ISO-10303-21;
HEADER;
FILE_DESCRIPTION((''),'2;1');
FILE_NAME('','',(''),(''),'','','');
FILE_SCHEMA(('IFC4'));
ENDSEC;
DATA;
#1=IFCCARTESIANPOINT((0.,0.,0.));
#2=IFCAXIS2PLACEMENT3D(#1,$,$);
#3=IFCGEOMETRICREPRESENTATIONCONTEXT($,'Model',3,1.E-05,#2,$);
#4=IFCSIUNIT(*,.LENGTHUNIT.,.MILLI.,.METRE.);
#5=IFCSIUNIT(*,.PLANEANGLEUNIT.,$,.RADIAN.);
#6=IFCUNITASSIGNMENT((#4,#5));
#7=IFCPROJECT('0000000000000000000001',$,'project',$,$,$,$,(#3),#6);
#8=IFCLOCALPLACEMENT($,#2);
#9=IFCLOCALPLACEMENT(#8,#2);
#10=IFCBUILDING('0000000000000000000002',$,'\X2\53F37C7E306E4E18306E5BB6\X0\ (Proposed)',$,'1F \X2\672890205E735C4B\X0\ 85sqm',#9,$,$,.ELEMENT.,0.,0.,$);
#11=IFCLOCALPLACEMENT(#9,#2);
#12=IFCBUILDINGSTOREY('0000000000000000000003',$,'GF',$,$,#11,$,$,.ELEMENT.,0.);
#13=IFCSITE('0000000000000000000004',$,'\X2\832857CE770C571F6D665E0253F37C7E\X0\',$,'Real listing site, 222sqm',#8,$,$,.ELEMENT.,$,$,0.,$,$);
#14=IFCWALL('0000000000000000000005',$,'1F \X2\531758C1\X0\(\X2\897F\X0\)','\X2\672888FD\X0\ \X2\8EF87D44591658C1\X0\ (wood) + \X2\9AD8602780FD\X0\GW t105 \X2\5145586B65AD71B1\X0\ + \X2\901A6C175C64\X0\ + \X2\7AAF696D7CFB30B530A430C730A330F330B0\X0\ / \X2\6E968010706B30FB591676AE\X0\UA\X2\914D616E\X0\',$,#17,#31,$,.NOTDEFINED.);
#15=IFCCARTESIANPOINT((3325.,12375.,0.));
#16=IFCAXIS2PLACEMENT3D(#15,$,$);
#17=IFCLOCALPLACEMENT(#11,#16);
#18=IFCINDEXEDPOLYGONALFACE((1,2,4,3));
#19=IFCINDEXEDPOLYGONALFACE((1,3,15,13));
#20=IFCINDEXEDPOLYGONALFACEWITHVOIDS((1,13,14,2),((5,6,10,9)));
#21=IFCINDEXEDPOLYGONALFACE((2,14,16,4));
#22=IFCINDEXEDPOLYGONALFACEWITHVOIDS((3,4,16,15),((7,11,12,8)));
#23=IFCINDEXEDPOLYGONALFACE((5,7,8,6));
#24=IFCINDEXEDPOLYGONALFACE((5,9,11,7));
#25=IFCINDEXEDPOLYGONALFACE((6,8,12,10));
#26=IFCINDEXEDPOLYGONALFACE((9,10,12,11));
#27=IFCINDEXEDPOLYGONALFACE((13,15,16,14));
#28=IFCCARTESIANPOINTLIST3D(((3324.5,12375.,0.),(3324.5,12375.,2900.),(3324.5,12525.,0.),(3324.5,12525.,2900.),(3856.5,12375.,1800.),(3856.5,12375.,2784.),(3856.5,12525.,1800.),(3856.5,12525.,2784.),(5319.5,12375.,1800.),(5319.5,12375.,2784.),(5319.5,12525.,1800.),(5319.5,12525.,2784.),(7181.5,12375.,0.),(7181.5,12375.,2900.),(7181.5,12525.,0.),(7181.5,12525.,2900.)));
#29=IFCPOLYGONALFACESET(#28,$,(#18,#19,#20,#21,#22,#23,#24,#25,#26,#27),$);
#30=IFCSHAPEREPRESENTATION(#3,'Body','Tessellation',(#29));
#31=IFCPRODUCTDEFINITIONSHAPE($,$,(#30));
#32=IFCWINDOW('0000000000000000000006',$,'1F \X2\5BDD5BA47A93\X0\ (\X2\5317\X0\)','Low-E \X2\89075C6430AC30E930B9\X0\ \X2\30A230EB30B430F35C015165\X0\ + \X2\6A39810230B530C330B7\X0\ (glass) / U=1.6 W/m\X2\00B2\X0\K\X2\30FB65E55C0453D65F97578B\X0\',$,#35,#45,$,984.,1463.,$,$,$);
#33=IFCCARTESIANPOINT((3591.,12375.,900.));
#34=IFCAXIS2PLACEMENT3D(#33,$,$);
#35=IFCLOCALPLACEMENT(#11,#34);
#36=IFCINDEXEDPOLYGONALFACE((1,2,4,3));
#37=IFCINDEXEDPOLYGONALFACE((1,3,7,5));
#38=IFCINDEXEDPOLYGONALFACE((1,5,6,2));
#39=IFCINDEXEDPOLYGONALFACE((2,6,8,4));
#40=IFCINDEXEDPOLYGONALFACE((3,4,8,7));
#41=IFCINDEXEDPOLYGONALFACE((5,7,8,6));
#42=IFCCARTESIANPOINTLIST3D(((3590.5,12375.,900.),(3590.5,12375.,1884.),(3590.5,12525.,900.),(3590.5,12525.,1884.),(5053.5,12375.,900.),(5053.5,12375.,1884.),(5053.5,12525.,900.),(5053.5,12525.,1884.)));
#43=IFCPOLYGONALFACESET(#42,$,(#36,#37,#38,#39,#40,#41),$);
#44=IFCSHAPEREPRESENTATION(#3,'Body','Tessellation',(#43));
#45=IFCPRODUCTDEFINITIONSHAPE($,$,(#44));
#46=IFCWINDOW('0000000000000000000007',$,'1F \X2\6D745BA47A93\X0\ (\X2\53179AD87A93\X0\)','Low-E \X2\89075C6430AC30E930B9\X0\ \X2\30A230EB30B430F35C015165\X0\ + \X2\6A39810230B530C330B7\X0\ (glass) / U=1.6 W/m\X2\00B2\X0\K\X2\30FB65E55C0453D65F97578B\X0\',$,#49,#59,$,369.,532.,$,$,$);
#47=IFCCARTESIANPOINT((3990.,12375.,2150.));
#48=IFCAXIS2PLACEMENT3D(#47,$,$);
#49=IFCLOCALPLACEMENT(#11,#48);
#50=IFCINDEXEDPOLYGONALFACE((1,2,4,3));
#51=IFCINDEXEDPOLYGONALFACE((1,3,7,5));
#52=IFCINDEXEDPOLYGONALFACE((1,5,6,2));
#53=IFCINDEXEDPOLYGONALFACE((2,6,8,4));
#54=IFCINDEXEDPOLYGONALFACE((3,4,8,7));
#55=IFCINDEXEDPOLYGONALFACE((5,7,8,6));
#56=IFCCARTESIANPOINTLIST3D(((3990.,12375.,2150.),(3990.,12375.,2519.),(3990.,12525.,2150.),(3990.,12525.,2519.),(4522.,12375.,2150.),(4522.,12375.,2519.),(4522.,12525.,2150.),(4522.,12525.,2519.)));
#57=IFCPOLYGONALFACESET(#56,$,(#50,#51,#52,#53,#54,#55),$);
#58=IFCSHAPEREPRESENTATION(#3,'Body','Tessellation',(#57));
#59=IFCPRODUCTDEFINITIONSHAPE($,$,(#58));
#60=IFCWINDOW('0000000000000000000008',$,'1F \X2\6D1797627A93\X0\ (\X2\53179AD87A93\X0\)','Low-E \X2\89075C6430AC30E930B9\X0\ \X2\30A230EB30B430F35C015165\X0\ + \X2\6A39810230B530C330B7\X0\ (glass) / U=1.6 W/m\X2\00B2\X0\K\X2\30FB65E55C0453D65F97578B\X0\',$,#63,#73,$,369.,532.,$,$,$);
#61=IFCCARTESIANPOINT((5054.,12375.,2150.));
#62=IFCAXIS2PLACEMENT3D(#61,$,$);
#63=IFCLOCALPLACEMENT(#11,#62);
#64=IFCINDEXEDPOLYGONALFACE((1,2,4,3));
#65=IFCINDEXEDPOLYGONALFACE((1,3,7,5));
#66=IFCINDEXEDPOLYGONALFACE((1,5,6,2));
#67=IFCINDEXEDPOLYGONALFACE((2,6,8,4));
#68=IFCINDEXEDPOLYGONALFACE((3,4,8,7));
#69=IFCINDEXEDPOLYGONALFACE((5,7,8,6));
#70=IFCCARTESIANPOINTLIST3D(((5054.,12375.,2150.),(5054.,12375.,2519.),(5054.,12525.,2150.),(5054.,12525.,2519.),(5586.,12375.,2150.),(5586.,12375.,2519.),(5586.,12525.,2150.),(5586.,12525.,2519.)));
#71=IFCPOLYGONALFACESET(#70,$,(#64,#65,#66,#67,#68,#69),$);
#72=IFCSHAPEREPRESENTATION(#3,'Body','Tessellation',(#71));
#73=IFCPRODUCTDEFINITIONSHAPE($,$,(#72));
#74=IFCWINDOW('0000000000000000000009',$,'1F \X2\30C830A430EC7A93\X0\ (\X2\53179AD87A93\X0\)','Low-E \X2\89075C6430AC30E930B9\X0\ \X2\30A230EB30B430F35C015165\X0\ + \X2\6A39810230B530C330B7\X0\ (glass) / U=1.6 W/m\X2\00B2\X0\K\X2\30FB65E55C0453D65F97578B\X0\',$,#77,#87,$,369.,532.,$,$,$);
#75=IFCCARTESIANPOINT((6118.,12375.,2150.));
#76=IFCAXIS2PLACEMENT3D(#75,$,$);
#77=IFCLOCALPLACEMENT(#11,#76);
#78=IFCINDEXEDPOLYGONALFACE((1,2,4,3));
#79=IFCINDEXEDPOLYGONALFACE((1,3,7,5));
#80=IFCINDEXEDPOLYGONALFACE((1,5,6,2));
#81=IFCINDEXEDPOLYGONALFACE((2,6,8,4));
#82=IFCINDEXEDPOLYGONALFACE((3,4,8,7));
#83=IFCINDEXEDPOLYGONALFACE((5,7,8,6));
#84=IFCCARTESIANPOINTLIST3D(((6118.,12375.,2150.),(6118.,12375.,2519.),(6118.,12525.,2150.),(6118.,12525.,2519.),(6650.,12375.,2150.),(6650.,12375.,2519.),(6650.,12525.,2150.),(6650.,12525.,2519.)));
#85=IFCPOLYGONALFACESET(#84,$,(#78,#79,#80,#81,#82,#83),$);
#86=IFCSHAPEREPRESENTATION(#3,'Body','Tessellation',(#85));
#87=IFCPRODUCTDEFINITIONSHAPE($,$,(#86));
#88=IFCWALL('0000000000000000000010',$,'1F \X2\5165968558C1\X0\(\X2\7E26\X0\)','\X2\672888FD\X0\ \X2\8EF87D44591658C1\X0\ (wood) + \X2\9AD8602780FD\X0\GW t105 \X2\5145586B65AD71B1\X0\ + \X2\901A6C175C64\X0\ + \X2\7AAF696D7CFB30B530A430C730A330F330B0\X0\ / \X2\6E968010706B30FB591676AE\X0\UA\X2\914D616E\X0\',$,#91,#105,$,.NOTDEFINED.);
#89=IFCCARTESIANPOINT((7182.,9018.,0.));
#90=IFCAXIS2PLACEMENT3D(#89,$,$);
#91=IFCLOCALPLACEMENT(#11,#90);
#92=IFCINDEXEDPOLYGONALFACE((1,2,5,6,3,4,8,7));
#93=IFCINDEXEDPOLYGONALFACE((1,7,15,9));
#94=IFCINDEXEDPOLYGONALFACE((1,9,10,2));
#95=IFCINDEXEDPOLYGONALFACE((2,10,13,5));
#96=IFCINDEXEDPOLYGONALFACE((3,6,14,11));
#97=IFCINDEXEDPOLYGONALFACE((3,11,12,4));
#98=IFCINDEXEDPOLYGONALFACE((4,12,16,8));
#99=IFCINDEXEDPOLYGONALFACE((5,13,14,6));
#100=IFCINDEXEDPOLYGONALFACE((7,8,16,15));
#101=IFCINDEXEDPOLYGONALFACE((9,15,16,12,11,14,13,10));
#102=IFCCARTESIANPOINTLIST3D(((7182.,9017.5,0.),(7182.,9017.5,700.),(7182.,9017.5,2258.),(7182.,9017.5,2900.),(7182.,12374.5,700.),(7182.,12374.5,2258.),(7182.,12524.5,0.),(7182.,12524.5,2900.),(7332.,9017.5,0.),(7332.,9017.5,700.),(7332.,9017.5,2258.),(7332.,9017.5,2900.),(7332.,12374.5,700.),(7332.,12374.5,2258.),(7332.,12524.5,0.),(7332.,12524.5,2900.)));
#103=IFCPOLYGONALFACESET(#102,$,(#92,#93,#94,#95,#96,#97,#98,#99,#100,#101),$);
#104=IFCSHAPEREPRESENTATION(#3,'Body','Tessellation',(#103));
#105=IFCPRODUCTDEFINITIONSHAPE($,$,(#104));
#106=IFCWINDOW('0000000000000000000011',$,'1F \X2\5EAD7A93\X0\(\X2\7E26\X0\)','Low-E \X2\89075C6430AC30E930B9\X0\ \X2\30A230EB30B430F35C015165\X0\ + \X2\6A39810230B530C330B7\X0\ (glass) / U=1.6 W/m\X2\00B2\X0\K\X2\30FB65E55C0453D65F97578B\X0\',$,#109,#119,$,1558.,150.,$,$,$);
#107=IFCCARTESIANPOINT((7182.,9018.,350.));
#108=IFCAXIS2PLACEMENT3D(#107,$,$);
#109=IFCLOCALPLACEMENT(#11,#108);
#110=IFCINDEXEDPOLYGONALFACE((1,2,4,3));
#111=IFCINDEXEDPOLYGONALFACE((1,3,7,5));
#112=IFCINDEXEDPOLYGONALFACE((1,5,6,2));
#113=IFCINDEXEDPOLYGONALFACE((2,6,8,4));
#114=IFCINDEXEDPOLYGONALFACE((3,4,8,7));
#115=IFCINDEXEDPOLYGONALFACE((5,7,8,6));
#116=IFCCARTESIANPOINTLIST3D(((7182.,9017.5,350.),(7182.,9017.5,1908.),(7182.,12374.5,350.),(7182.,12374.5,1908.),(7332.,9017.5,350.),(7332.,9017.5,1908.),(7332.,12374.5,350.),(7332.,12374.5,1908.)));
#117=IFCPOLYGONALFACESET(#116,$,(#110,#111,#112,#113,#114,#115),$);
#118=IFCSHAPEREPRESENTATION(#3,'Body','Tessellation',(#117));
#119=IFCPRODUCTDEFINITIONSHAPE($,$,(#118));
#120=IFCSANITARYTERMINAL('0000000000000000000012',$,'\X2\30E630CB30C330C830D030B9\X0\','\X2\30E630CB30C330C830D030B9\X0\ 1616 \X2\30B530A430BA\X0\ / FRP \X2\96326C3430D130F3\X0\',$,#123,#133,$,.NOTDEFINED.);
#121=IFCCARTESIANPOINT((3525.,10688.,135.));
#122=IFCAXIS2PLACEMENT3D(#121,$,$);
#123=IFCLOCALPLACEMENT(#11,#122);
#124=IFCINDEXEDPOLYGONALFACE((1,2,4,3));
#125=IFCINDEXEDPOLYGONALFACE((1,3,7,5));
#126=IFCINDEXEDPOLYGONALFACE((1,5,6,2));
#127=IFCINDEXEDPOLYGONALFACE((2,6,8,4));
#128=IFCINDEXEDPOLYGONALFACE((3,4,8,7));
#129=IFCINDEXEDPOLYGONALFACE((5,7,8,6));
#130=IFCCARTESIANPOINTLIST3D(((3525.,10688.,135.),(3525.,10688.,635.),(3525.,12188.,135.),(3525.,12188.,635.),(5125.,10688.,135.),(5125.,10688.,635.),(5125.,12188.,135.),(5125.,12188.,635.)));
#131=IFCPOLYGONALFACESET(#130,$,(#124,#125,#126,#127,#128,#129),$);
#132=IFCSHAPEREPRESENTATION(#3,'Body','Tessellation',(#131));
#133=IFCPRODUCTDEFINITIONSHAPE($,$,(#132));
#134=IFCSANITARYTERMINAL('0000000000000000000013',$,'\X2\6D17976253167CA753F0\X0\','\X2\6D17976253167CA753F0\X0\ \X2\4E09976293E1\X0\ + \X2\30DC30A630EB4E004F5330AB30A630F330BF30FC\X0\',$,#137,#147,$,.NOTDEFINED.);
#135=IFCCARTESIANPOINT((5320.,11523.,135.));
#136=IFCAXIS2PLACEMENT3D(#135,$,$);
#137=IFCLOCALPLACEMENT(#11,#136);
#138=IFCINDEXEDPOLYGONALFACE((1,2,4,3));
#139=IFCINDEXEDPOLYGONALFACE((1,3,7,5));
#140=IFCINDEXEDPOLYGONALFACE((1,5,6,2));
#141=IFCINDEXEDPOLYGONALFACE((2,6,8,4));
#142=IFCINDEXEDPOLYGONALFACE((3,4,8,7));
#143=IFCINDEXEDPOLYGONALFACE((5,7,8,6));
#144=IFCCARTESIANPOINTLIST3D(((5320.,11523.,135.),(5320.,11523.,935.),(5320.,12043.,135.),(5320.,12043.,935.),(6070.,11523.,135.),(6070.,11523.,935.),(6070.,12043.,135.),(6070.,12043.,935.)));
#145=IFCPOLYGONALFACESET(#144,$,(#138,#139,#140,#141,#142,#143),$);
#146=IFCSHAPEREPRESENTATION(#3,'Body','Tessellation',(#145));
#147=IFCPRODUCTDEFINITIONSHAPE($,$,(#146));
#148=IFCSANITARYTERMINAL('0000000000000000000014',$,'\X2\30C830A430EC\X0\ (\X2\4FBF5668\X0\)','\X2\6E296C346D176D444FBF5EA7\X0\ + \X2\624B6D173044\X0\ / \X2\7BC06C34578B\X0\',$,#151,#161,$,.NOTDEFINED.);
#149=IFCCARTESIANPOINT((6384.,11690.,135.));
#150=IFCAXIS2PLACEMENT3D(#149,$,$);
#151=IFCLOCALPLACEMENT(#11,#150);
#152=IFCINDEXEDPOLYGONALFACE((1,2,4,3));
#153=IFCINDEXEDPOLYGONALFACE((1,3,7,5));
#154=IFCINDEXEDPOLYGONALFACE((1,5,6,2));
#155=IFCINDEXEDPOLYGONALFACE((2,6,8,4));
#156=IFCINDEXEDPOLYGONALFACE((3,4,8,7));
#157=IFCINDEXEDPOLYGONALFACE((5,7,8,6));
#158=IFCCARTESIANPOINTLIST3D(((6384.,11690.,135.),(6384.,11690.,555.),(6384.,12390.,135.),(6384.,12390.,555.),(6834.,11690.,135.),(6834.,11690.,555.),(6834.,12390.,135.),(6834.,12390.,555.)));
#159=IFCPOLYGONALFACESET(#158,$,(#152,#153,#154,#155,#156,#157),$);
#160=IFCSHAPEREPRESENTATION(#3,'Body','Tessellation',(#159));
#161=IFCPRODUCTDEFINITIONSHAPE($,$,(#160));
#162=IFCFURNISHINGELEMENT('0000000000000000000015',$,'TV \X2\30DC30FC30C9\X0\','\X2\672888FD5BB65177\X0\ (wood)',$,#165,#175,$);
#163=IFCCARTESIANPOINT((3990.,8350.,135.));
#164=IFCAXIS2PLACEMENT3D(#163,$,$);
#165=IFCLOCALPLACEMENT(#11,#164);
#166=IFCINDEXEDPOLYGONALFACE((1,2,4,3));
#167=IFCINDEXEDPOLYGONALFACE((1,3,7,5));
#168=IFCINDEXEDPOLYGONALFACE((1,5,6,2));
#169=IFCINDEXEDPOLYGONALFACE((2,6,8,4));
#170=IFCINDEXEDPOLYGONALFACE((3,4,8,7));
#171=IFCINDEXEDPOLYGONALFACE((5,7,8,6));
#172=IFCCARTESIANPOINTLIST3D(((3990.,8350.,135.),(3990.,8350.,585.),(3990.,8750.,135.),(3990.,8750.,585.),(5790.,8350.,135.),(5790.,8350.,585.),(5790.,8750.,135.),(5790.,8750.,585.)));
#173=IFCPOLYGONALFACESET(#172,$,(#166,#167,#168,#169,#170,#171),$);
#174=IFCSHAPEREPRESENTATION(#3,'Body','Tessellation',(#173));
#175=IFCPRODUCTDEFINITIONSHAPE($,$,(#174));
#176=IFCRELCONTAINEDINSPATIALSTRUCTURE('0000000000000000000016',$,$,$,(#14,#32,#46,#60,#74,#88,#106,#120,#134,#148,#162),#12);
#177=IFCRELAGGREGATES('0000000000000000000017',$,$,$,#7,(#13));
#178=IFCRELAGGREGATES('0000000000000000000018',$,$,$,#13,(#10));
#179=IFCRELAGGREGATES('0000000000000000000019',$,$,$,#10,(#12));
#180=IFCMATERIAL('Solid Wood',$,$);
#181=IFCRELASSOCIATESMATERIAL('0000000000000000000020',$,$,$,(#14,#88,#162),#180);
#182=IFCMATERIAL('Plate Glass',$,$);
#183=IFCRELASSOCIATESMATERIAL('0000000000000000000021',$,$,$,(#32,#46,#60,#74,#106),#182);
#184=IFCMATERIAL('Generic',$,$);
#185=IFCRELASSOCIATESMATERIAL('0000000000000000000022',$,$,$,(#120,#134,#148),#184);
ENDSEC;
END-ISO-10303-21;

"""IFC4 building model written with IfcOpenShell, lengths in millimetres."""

from ifc_helpers import new_model, si_unit, frame, frame_2d, origin, place, context, project, spatial, rectangle, extrude, material, element, fill, save


model = new_model("IFC4")

# Units and contexts
model_context = context("Model", 3, precision=1e-05, world=origin())
ifc_project = project(units=[si_unit("LENGTHUNIT", "METRE", prefix="MILLI"), si_unit("PLANEANGLEUNIT", "RADIAN")], contexts=[model_context])

# Site, building, storey
site_placement = place(None, origin())
site = spatial("IfcSite", under=ifc_project, at=site_placement, Name="茨城県土浦市右籾", ObjectType="Real listing site, 222sqm", CompositionType="ELEMENT", RefElevation=0.0)
building_placement = place(site_placement, origin())
building = spatial("IfcBuilding", under=site, at=building_placement, Name="右籾の丘の家 (Proposed)", ObjectType="1F 木造平屋 85sqm", CompositionType="ELEMENT", ElevationOfRefHeight=0.0, ElevationOfTerrain=0.0)
storey_placement = place(building_placement, origin())
storey = spatial("IfcBuildingStorey", under=building, at=storey_placement, Name="GF", CompositionType="ELEMENT", Elevation=0.0)

# Shared definitions
ifc_material_1 = material(Name="Solid Wood")

# Wall, openings, windows
wall_1_placement = place(storey_placement, frame((3325.0, 12375.0, 0.0)))
wall_1 = element("IfcWall", 1, at=wall_1_placement, inside=storey, material=ifc_material_1, Name="1F 北壁(西)", Description="木製 軸組外壁 (wood) + 高性能GW t105 充填断熱 + 通気層 + 窯業系サイディング / 準耐火・外皮UA配慮", PredefinedType="NOTDEFINED", context=model_context, shape_type="SweptSolid", body=[
    extrude(rectangle(XDim=3857.0, YDim=150.0, at=frame_2d((1928.0, 75.0))), frame((3325.0, 12375.0, 0.0)), (0.0, 0.0, 1.0), 2900.0),
])
opening_1_placement = place(storey_placement, frame((3591.0, 12375.0, 900.0)))
opening_1 = element("IfcOpeningElement", 2, at=opening_1_placement, cuts=wall_1, PredefinedType="NOTDEFINED", context=model_context, shape_type="SweptSolid", body=[
    extrude(rectangle(XDim=1463.0, YDim=150.0, at=frame_2d((731.0, 75.0))), frame((3591.0, 12375.0, 900.0)), (0.0, 0.0, 1.0), 984.0),
])
opening_2_placement = place(storey_placement, frame((3990.0, 12375.0, 2150.0)))
opening_2 = element("IfcOpeningElement", 3, at=opening_2_placement, cuts=wall_1, PredefinedType="NOTDEFINED", context=model_context, shape_type="SweptSolid", body=[
    extrude(rectangle(XDim=532.0, YDim=150.0, at=frame_2d((266.0, 75.0))), frame((3990.0, 12375.0, 2150.0)), (0.0, 0.0, 1.0), 369.0),
])
opening_3_placement = place(storey_placement, frame((5054.0, 12375.0, 2150.0)))
opening_3 = element("IfcOpeningElement", 4, at=opening_3_placement, cuts=wall_1, PredefinedType="NOTDEFINED", context=model_context, shape_type="SweptSolid", body=[
    extrude(rectangle(XDim=532.0, YDim=150.0, at=frame_2d((266.0, 75.0))), frame((5054.0, 12375.0, 2150.0)), (0.0, 0.0, 1.0), 369.0),
])
opening_4_placement = place(storey_placement, frame((6118.0, 12375.0, 2150.0)))
opening_4 = element("IfcOpeningElement", 5, at=opening_4_placement, cuts=wall_1, PredefinedType="NOTDEFINED", context=model_context, shape_type="SweptSolid", body=[
    extrude(rectangle(XDim=532.0, YDim=150.0, at=frame_2d((266.0, 75.0))), frame((6118.0, 12375.0, 2150.0)), (0.0, 0.0, 1.0), 369.0),
])
ifc_material_2 = material(Name="Plate Glass")
window_1_placement = place(storey_placement, frame((3591.0, 12375.0, 900.0)))
window_1 = element("IfcWindow", 6, at=window_1_placement, inside=storey, material=ifc_material_2, Name="1F 寝室窓 (北)", Description="Low-E 複層ガラス アルゴン封入 + 樹脂サッシ (glass) / U=1.6 W/m²K・日射取得型", OverallHeight=984.0, OverallWidth=1463.0, context=model_context, shape_type="SweptSolid", body=[
    extrude(rectangle(XDim=1463.0, YDim=150.0, at=frame_2d((731.0, 75.0))), frame((3591.0, 12375.0, 900.0)), (0.0, 0.0, 1.0), 984.0),
])
fill(opening_1, window_1)
window_2_placement = place(storey_placement, frame((3990.0, 12375.0, 2150.0)))
window_2 = element("IfcWindow", 7, at=window_2_placement, inside=storey, material=ifc_material_2, Name="1F 浴室窓 (北高窓)", Description="Low-E 複層ガラス アルゴン封入 + 樹脂サッシ (glass) / U=1.6 W/m²K・日射取得型", OverallHeight=369.0, OverallWidth=532.0, context=model_context, shape_type="SweptSolid", body=[
    extrude(rectangle(XDim=532.0, YDim=150.0, at=frame_2d((266.0, 75.0))), frame((3990.0, 12375.0, 2150.0)), (0.0, 0.0, 1.0), 369.0),
])
fill(opening_2, window_2)
window_3_placement = place(storey_placement, frame((5054.0, 12375.0, 2150.0)))
window_3 = element("IfcWindow", 8, at=window_3_placement, inside=storey, material=ifc_material_2, Name="1F 洗面窓 (北高窓)", Description="Low-E 複層ガラス アルゴン封入 + 樹脂サッシ (glass) / U=1.6 W/m²K・日射取得型", OverallHeight=369.0, OverallWidth=532.0, context=model_context, shape_type="SweptSolid", body=[
    extrude(rectangle(XDim=532.0, YDim=150.0, at=frame_2d((266.0, 75.0))), frame((5054.0, 12375.0, 2150.0)), (0.0, 0.0, 1.0), 369.0),
])
fill(opening_3, window_3)
window_4_placement = place(storey_placement, frame((6118.0, 12375.0, 2150.0)))
window_4 = element("IfcWindow", 9, at=window_4_placement, inside=storey, material=ifc_material_2, Name="1F トイレ窓 (北高窓)", Description="Low-E 複層ガラス アルゴン封入 + 樹脂サッシ (glass) / U=1.6 W/m²K・日射取得型", OverallHeight=369.0, OverallWidth=532.0, context=model_context, shape_type="SweptSolid", body=[
    extrude(rectangle(XDim=532.0, YDim=150.0, at=frame_2d((266.0, 75.0))), frame((6118.0, 12375.0, 2150.0)), (0.0, 0.0, 1.0), 369.0),
])
fill(opening_4, window_4)

# Wall, opening, window
wall_2_placement = place(storey_placement, frame((7182.0, 9018.0, 0.0)))
wall_2 = element("IfcWall", 10, at=wall_2_placement, inside=storey, material=ifc_material_1, Name="1F 入隅壁(縦)", Description="木製 軸組外壁 (wood) + 高性能GW t105 充填断熱 + 通気層 + 窯業系サイディング / 準耐火・外皮UA配慮", PredefinedType="NOTDEFINED", context=model_context, shape_type="SweptSolid", body=[
    extrude(rectangle(XDim=150.0, YDim=3507.0, at=frame_2d((75.0, 1753.0))), frame((7182.0, 9018.0, 0.0)), (0.0, 0.0, 1.0), 2900.0),
])
opening_5_placement = place(storey_placement, frame((7182.0, 9018.0, 350.0)))
opening_5 = element("IfcOpeningElement", 11, at=opening_5_placement, cuts=wall_2, PredefinedType="NOTDEFINED", context=model_context, shape_type="SweptSolid", body=[
    extrude(rectangle(XDim=150.0, YDim=3357.0, at=frame_2d((75.0, 1678.0))), frame((7182.0, 9018.0, 350.0)), (0.0, 0.0, 1.0), 1558.0),
])
window_5_placement = place(storey_placement, frame((7182.0, 9018.0, 350.0)))
window_5 = element("IfcWindow", 12, at=window_5_placement, inside=storey, material=ifc_material_2, Name="1F 庭窓(縦)", Description="Low-E 複層ガラス アルゴン封入 + 樹脂サッシ (glass) / U=1.6 W/m²K・日射取得型", OverallHeight=1558.0, OverallWidth=150.0, context=model_context, shape_type="SweptSolid", body=[
    extrude(rectangle(XDim=150.0, YDim=3357.0, at=frame_2d((75.0, 1678.0))), frame((7182.0, 9018.0, 350.0)), (0.0, 0.0, 1.0), 1558.0),
])
fill(opening_5, window_5)

# Shared definitions
ifc_material_3 = material(Name="Generic")

# Sanitary terminals
sanitary_terminal_1_placement = place(storey_placement, frame((3525.0, 10688.0, 135.0)))
element("IfcSanitaryTerminal", 13, at=sanitary_terminal_1_placement, inside=storey, material=ifc_material_3, Name="ユニットバス", Description="ユニットバス 1616 サイズ / FRP 防水パン", PredefinedType="NOTDEFINED", context=model_context, shape_type="SweptSolid", body=[
    extrude(rectangle(XDim=1600.0, YDim=1500.0, at=frame_2d((800.0, 750.0))), frame((3525.0, 10688.0, 135.0)), (0.0, 0.0, 1.0), 500.0),
])
sanitary_terminal_2_placement = place(storey_placement, frame((5320.0, 11523.0, 135.0)))
element("IfcSanitaryTerminal", 14, at=sanitary_terminal_2_placement, inside=storey, material=ifc_material_3, Name="洗面化粧台", Description="洗面化粧台 三面鏡 + ボウル一体カウンター", PredefinedType="NOTDEFINED", context=model_context, shape_type="SweptSolid", body=[
    extrude(rectangle(XDim=750.0, YDim=520.0, at=frame_2d((375.0, 260.0))), frame((5320.0, 11523.0, 135.0)), (0.0, 0.0, 1.0), 800.0),
])
sanitary_terminal_3_placement = place(storey_placement, frame((6384.0, 11690.0, 135.0)))
element("IfcSanitaryTerminal", 15, at=sanitary_terminal_3_placement, inside=storey, material=ifc_material_3, Name="トイレ (便器)", Description="温水洗浄便座 + 手洗い / 節水型", PredefinedType="NOTDEFINED", context=model_context, shape_type="SweptSolid", body=[
    extrude(rectangle(XDim=450.0, YDim=700.0, at=frame_2d((225.0, 350.0))), frame((6384.0, 11690.0, 135.0)), (0.0, 0.0, 1.0), 420.0),
])

# Furnishing element
furnishing_placement = place(storey_placement, frame((3990.0, 8350.0, 135.0)))
element("IfcFurnishingElement", 16, at=furnishing_placement, inside=storey, material=ifc_material_1, Name="TV ボード", Description="木製家具 (wood)", context=model_context, shape_type="SweptSolid", body=[
    extrude(rectangle(XDim=1800.0, YDim=400.0, at=frame_2d((900.0, 200.0))), frame((3990.0, 8350.0, 135.0)), (0.0, 0.0, 1.0), 450.0),
])

save(model, "model.ifc")
